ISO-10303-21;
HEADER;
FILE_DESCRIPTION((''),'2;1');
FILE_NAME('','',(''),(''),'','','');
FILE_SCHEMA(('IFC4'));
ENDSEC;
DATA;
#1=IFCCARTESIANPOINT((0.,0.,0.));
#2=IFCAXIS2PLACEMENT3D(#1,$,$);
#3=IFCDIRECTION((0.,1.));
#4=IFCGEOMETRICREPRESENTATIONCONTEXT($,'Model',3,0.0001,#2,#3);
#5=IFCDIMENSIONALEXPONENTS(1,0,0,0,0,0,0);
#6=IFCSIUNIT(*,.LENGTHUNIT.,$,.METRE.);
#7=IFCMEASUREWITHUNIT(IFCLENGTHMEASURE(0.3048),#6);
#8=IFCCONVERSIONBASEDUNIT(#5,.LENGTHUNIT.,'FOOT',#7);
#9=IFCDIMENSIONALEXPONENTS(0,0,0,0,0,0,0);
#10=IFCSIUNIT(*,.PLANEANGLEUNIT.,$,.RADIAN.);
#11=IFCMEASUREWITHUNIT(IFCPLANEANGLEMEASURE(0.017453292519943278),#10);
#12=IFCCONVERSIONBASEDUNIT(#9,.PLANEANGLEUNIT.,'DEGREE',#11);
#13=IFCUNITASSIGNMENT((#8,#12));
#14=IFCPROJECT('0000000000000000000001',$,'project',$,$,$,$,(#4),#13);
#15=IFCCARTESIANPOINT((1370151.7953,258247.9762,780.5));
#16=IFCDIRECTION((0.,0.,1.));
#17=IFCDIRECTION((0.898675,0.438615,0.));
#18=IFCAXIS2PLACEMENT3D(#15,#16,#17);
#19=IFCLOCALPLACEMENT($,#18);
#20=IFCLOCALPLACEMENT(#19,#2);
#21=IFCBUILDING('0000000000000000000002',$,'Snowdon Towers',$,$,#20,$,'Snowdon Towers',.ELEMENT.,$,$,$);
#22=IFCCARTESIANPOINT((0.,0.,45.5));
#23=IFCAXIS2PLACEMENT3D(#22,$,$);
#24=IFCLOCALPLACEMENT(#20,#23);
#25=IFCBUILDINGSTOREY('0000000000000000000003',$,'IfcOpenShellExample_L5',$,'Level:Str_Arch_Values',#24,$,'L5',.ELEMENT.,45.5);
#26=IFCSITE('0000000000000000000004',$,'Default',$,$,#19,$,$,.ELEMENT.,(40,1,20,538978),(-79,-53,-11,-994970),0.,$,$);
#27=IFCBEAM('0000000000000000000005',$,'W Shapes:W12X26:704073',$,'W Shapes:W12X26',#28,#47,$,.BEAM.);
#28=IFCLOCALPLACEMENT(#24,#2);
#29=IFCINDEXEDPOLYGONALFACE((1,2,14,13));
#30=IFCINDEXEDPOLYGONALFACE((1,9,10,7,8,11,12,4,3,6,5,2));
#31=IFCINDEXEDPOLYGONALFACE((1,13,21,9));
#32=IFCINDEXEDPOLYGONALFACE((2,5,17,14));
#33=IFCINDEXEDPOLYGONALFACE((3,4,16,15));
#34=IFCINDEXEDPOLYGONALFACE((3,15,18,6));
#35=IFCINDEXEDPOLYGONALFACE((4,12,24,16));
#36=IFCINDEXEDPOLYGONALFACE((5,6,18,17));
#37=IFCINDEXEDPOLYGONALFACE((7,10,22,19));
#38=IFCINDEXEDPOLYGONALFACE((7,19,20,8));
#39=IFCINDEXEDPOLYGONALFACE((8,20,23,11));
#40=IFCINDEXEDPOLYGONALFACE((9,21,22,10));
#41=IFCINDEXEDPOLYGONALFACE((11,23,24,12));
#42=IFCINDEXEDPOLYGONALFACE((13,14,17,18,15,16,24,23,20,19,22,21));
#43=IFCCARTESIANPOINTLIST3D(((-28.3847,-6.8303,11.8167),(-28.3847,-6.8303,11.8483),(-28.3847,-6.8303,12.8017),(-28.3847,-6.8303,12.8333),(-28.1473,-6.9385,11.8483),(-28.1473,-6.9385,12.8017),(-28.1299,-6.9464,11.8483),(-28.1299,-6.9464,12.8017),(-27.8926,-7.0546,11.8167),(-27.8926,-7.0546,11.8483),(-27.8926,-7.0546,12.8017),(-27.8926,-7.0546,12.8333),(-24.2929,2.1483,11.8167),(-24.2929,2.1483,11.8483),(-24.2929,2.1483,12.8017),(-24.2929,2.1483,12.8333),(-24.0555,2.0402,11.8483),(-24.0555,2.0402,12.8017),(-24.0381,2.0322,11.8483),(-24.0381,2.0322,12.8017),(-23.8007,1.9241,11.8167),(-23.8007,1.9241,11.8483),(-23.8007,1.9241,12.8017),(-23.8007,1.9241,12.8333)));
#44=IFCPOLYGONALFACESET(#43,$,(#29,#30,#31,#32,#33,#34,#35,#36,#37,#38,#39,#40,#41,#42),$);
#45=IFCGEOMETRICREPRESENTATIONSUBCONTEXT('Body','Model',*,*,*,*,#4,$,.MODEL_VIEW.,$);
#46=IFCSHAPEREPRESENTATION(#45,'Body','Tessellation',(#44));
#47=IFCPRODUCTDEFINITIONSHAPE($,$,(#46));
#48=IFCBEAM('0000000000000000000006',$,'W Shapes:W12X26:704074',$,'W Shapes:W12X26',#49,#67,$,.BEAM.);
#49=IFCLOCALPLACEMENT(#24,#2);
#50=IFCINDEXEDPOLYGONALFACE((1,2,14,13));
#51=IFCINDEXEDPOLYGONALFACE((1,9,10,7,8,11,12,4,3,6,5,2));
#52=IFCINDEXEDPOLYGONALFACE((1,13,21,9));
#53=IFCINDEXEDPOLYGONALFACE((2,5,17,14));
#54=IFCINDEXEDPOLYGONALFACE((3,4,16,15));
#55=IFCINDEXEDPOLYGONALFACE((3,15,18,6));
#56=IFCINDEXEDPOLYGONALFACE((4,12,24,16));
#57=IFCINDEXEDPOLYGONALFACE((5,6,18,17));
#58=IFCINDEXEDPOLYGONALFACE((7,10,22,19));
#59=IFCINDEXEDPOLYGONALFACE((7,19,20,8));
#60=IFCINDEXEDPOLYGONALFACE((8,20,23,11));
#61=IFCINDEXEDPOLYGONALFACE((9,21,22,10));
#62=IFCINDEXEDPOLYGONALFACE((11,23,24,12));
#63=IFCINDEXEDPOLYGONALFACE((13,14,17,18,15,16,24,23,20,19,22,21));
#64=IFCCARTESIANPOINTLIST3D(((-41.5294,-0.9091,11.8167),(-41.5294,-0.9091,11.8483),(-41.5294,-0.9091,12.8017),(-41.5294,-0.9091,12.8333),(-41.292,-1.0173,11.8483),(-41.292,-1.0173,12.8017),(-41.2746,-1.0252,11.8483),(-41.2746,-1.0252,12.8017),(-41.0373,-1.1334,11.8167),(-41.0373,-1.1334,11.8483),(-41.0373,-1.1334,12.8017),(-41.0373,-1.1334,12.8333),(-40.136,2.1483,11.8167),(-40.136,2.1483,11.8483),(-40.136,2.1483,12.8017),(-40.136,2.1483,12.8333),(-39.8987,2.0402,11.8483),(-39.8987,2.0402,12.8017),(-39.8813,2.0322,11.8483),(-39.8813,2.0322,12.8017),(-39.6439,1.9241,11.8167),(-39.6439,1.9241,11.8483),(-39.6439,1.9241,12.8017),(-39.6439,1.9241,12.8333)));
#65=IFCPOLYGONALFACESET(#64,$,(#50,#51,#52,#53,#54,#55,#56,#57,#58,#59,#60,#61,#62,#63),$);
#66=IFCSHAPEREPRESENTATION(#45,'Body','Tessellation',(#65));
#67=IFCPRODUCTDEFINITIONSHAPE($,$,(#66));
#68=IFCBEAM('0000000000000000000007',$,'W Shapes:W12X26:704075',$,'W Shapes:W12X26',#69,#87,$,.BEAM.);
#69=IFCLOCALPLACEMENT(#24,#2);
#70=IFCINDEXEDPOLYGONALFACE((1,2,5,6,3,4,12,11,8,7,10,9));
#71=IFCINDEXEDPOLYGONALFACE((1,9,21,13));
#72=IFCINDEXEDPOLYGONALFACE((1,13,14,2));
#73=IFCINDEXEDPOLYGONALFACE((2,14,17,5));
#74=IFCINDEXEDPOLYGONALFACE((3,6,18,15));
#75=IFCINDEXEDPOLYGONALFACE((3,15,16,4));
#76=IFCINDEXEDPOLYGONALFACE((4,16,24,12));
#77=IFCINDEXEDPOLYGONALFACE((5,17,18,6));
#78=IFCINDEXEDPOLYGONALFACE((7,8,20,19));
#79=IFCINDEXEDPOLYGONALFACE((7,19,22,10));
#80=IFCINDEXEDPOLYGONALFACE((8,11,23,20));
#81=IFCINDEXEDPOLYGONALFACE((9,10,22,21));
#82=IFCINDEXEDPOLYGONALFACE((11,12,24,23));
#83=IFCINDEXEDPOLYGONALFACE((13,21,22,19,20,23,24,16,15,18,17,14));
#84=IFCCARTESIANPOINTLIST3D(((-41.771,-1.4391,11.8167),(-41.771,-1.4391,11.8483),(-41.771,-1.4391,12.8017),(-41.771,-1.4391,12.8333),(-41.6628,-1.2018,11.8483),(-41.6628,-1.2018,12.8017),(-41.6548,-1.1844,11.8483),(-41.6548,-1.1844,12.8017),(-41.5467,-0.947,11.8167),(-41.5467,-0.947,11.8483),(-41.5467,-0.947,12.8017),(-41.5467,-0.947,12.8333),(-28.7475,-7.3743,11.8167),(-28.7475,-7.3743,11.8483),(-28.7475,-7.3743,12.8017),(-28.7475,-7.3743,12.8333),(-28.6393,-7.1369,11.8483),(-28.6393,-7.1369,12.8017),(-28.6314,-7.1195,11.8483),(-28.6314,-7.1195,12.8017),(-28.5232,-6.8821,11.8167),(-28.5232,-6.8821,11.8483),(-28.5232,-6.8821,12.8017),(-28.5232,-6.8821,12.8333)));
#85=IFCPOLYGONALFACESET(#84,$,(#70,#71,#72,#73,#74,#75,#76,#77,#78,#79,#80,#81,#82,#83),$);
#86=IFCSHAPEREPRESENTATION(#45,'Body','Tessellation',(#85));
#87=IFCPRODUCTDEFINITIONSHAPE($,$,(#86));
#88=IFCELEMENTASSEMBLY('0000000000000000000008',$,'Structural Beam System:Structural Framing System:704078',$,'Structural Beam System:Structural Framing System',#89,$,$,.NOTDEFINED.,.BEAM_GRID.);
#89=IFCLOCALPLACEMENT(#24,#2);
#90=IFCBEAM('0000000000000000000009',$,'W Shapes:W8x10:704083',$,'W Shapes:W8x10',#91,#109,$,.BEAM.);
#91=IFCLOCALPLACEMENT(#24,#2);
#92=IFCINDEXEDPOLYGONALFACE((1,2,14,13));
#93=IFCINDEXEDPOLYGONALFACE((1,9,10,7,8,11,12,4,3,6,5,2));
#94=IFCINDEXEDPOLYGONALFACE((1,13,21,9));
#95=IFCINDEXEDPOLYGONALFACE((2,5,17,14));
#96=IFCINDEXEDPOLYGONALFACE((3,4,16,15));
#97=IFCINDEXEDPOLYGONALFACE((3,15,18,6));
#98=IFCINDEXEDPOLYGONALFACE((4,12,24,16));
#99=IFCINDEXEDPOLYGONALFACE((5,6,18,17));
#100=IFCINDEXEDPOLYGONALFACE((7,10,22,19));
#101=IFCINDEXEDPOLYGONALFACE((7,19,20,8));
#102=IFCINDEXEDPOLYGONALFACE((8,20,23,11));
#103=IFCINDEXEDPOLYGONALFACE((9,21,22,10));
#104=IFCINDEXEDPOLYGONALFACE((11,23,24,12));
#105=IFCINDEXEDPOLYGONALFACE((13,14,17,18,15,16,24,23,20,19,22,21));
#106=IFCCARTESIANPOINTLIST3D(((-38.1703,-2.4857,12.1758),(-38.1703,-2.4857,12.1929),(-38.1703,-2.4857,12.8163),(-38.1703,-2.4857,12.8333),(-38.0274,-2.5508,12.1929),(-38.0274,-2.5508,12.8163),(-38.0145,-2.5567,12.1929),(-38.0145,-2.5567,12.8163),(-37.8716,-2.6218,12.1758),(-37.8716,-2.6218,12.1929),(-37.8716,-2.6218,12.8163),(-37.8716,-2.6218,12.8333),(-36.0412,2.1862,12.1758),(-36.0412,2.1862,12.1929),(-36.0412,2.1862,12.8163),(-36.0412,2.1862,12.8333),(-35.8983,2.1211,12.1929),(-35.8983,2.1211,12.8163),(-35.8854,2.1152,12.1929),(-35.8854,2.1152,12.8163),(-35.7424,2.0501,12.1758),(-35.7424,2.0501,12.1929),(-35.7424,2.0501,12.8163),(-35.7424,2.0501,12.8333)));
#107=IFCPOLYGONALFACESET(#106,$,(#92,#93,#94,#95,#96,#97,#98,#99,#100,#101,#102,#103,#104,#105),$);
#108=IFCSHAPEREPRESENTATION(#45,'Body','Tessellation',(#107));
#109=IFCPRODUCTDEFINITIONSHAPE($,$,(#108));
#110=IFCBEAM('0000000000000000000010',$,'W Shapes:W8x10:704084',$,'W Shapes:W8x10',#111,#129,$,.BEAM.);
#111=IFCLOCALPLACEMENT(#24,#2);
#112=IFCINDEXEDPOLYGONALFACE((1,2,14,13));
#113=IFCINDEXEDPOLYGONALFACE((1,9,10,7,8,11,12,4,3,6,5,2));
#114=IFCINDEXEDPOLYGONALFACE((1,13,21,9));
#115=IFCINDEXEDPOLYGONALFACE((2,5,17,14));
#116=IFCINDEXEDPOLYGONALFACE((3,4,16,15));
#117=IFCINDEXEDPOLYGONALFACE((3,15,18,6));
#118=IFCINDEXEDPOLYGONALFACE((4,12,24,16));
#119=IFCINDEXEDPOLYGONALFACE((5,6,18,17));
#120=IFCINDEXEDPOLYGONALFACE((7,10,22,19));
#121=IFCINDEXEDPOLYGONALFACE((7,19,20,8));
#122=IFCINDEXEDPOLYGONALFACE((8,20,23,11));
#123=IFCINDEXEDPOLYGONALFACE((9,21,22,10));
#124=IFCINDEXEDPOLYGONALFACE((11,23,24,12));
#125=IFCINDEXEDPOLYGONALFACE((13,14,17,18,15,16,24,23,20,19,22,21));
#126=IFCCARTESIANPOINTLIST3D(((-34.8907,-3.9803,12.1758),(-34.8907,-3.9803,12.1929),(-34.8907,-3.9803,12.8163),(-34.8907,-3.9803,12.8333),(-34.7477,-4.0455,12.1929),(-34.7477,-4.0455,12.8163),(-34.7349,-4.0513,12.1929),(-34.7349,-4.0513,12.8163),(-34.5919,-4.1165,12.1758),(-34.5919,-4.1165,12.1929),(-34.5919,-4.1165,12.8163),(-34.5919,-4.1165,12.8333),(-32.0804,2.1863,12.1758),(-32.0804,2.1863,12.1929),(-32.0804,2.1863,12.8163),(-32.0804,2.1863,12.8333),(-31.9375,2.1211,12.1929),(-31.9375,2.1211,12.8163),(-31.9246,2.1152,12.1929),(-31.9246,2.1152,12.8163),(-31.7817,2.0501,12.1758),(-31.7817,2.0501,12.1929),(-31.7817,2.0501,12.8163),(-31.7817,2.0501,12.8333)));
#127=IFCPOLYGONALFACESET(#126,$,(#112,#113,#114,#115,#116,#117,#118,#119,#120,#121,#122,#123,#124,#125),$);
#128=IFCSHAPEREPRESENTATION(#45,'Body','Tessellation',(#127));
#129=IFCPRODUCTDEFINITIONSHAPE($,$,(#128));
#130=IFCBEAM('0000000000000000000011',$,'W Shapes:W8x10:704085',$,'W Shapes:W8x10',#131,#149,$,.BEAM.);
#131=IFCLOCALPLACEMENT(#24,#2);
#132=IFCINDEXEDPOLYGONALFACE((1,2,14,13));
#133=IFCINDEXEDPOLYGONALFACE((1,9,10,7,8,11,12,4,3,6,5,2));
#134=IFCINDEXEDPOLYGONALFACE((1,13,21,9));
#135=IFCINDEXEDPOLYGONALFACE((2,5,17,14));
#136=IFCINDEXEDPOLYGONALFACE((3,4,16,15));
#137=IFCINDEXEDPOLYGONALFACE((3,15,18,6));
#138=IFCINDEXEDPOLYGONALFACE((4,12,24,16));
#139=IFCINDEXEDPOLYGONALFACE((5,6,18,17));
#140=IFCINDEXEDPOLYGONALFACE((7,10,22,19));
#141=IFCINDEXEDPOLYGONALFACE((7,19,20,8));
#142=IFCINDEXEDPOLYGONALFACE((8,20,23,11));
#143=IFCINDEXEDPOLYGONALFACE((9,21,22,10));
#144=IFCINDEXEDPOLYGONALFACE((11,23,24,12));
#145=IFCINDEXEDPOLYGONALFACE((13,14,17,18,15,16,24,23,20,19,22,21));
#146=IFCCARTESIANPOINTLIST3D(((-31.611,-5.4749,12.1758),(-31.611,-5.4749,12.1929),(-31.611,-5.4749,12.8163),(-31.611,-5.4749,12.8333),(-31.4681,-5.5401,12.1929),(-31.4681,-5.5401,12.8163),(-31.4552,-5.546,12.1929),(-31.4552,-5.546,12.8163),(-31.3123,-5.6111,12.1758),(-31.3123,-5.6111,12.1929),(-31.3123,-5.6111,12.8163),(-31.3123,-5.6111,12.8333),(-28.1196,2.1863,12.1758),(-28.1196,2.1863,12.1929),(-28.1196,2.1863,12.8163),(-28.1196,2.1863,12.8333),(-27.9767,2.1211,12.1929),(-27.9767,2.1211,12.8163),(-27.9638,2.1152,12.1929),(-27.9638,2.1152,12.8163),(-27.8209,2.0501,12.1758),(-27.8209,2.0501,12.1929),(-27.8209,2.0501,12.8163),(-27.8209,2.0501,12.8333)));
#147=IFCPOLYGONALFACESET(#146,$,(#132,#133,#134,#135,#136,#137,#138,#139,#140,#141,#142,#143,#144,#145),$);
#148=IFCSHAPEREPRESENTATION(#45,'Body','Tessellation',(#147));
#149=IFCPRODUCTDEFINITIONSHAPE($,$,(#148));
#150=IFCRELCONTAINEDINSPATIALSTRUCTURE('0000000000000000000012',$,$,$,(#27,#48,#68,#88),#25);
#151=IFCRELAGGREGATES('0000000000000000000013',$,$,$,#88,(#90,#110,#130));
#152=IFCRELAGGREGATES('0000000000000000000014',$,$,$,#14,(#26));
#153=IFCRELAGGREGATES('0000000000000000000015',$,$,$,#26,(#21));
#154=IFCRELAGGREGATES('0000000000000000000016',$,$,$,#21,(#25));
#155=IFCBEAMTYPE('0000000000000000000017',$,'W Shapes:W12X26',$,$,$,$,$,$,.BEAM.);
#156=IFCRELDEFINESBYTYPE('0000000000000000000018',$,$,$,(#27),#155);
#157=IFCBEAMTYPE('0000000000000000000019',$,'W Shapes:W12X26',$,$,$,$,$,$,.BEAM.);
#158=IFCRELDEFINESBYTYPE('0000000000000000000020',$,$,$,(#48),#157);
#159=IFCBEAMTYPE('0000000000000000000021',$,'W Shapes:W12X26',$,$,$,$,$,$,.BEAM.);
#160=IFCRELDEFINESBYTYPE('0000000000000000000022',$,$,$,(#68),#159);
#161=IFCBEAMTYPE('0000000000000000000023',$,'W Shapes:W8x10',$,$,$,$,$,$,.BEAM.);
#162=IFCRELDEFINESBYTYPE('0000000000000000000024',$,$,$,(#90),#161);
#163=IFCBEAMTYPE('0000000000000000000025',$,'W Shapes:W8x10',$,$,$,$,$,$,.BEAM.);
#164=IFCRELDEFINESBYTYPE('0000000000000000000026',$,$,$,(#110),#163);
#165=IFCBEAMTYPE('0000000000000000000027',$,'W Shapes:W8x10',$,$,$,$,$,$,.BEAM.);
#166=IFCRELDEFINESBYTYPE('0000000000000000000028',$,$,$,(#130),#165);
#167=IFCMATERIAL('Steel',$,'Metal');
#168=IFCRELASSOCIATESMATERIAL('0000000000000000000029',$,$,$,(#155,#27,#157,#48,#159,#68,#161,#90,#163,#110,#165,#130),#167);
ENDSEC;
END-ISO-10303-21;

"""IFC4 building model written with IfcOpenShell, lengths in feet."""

from ifc_helpers import new_model, entity, si_unit, converted_unit, direction, frame, origin, place, context, subcontext, project, spatial, indexed_curve, outline, extrude, source, transform, mapped, material, type_object, type_shapes, element, aggregate, save


model = new_model("IFC4")

# Units and contexts
model_context = context("Model", 3, precision=0.0001, world=origin(), true_north=direction((0.0, 1.0)))
body_context = subcontext(model_context, "Body", "Model", "MODEL_VIEW")
ifc_project = project(units=[converted_unit("LENGTHUNIT", "FOOT", entity("IfcLengthMeasure", 0.3048), si_unit("LENGTHUNIT", "METRE"), dimensions=[1, 0, 0, 0, 0, 0, 0]), converted_unit("PLANEANGLEUNIT", "DEGREE", entity("IfcPlaneAngleMeasure", 0.017453292519943278), si_unit("PLANEANGLEUNIT", "RADIAN"), dimensions=[0, 0, 0, 0, 0, 0, 0])], contexts=[model_context])

# Site, building, storey
site_placement = place(None, frame((1370151.7953, 258247.9762, 780.5), z_axis=(0.0, 0.0, 1.0), x_axis=(0.898675, 0.438615, 0.0)))
site = spatial("IfcSite", under=ifc_project, at=site_placement, Name="Default", CompositionType="ELEMENT", RefLatitude=(40, 1, 20, 538978), RefLongitude=(-79, -53, -11, -994970), RefElevation=0.0)
building_placement = place(site_placement, origin())
building = spatial("IfcBuilding", under=site, at=building_placement, Name="Snowdon Towers", LongName="Snowdon Towers", CompositionType="ELEMENT")
storey_placement = place(building_placement, frame((0.0, 0.0, 45.5)))
storey = spatial("IfcBuildingStorey", under=building, at=storey_placement, Name="IfcOpenShellExample_L5", ObjectType="Level:Str_Arch_Values", LongName="L5", CompositionType="ELEMENT", Elevation=45.5)

# Shared definitions
ifc_material = material(Name="Steel", Category="Metal")

# Beams
beam_type_1 = type_object("IfcBeamType", Name="W Shapes:W12X26", PredefinedType="BEAM", material=ifc_material)
shared_shape_1 = source(origin(), body_context, "Body", "SweptSolid", [
    extrude(outline(indexed_curve([(-0.2704, -0.4767), (-0.2704, -0.5083), (0.2704, -0.5083), (0.2704, -0.4767), (0.0096, -0.4767), (0.0096, 0.4767), (0.2704, 0.4767), (0.2704, 0.5083), (-0.2704, 0.5083), (-0.2704, 0.4767), (-0.0096, 0.4767), (-0.0096, -0.4767), (-0.2704, -0.4767)], self_intersect=False)), frame((-5.0009, 0.0, 0.0), z_axis=(-1.0, 0.0, 0.0), x_axis=(0.0, -1.0, 0.0)), (0.0, 0.0, -1.0), 9.8671),
])
type_shapes(beam_type_1, [shared_shape_1])
beam_1_placement = place(storey_placement, frame((-26.0648, -2.3919, 12.325), z_axis=(0.0, 0.0, 1.0), x_axis=(0.414693, 0.909961, 0.0)))
element("IfcBeam", 1, at=beam_1_placement, inside=storey, type_object=beam_type_1, material=ifc_material, Name="W Shapes:W12X26:704073", ObjectType="W Shapes:W12X26", PredefinedType="BEAM", context=body_context, shape_type="MappedRepresentation", body=[
    mapped(shared_shape_1, transform((0.0, 0.0, 0.0), scale=1.0)),
])
beam_type_2 = type_object("IfcBeamType", Name="W Shapes:W12X26", PredefinedType="BEAM", material=ifc_material)
shared_shape_2 = source(origin(), body_context, "Body", "SweptSolid", [
    extrude(outline(indexed_curve([(-0.2704, -0.4767), (-0.2704, -0.5083), (0.2704, -0.5083), (0.2704, -0.4767), (0.0096, -0.4767), (0.0096, 0.4767), (0.2704, 0.4767), (0.2704, 0.5083), (-0.2704, 0.5083), (-0.2704, 0.4767), (-0.0096, 0.4767), (-0.0096, -0.4767), (-0.2704, -0.4767)], self_intersect=False)), frame((-1.7788, 0.0, 0.0), z_axis=(-1.0, 0.0, 0.0), x_axis=(0.0, -1.0, 0.0)), (0.0, 0.0, -1.0), 3.3599),
])
type_shapes(beam_type_2, [shared_shape_2])
beam_2_placement = place(storey_placement, frame((-40.5457, 0.5974, 12.325), z_axis=(0.0, 0.0, 1.0), x_axis=(0.414693, 0.909961, 0.0)))
element("IfcBeam", 2, at=beam_2_placement, inside=storey, type_object=beam_type_2, material=ifc_material, Name="W Shapes:W12X26:704074", ObjectType="W Shapes:W12X26", PredefinedType="BEAM", context=body_context, shape_type="MappedRepresentation", body=[
    mapped(shared_shape_2, transform((0.0, 0.0, 0.0), scale=1.0)),
])
beam_type_3 = type_object("IfcBeamType", Name="W Shapes:W12X26", PredefinedType="BEAM", material=ifc_material)
shared_shape_3 = source(origin(), body_context, "Body", "SweptSolid", [
    extrude(outline(indexed_curve([(-0.2704, -0.4767), (-0.2704, -0.5083), (0.2704, -0.5083), (0.2704, -0.4767), (0.0096, -0.4767), (0.0096, 0.4767), (0.2704, 0.4767), (0.2704, 0.5083), (-0.2704, 0.5083), (-0.2704, 0.4767), (-0.0096, 0.4767), (-0.0096, -0.4767), (-0.2704, -0.4767)], self_intersect=False)), frame((-7.4788, 0.0, 0.0), z_axis=(-1.0, 0.0, 0.0), x_axis=(0.0, -1.0, 0.0)), (0.0, 0.0, -1.0), 14.3121),
])
type_shapes(beam_type_3, [shared_shape_3])
beam_3_placement = place(storey_placement, frame((-34.8534, -4.2945, 12.325), z_axis=(0.0, 0.0, 1.0), x_axis=(0.909961, -0.414693, 0.0)))
element("IfcBeam", 3, at=beam_3_placement, inside=storey, type_object=beam_type_3, material=ifc_material, Name="W Shapes:W12X26:704075", ObjectType="W Shapes:W12X26", PredefinedType="BEAM", context=body_context, shape_type="MappedRepresentation", body=[
    mapped(shared_shape_3, transform((0.0, 0.0, 0.0), scale=1.0)),
])

# Element assembly, beams
assembly_1_placement = place(storey_placement, origin())
assembly_1 = element("IfcElementAssembly", 4, at=assembly_1_placement, inside=storey, Name="Structural Beam System:Structural Framing System:704078", ObjectType="Structural Beam System:Structural Framing System", AssemblyPlace="NOTDEFINED", PredefinedType="BEAM_GRID")
beam_type_4 = type_object("IfcBeamType", Name="W Shapes:W8x10", PredefinedType="BEAM", material=ifc_material)
shared_shape_4 = source(origin(), body_context, "Body", "SweptSolid", [
    extrude(outline(indexed_curve([(-0.1642, -0.3117), (-0.1642, -0.3288), (0.1642, -0.3288), (0.1642, -0.3117), (0.0071, -0.3117), (0.0071, 0.3117), (0.1642, 0.3117), (0.1642, 0.3287), (-0.1642, 0.3287), (-0.1642, 0.3117), (-0.0071, 0.3117), (-0.0071, -0.3117), (-0.1642, -0.3117)], self_intersect=False)), frame((-2.6417, 0.0, 0.0), z_axis=(-1.0, 0.0, 0.0), x_axis=(0.0, -1.0, 0.0)), (0.0, 0.0, -1.0), 5.1342),
])
type_shapes(beam_type_4, [shared_shape_4])
beam_4_placement = place(assembly_1_placement, frame((-36.9255, -0.1499, 12.5046), z_axis=(0.0, 0.0, 1.0), x_axis=(0.414693, 0.909961, 0.0)))
beam_4 = element("IfcBeam", 5, at=beam_4_placement, type_object=beam_type_4, material=ifc_material, Name="W Shapes:W8x10:704083", ObjectType="W Shapes:W8x10", PredefinedType="BEAM", context=body_context, shape_type="MappedRepresentation", body=[
    mapped(shared_shape_4, transform((0.0, 0.0, 0.0), scale=1.0)),
])
beam_type_5 = type_object("IfcBeamType", Name="W Shapes:W8x10", PredefinedType="BEAM", material=ifc_material)
shared_shape_5 = source(origin(), body_context, "Body", "SweptSolid", [
    extrude(outline(indexed_curve([(-0.1642, -0.3117), (-0.1642, -0.3288), (0.1642, -0.3288), (0.1642, -0.3117), (0.0071, -0.3117), (0.0071, 0.3117), (0.1642, 0.3117), (0.1642, 0.3287), (-0.1642, 0.3287), (-0.1642, 0.3117), (-0.0071, 0.3117), (-0.0071, -0.3117), (-0.1642, -0.3117)], self_intersect=False)), frame((-3.463, 0.0, 0.0), z_axis=(-1.0, 0.0, 0.0), x_axis=(0.0, -1.0, 0.0)), (0.0, 0.0, -1.0), 6.7767),
])
type_shapes(beam_type_5, [shared_shape_5])
beam_5_placement = place(assembly_1_placement, frame((-33.3052, -0.8972, 12.5046), z_axis=(0.0, 0.0, 1.0), x_axis=(0.414693, 0.909961, 0.0)))
beam_5 = element("IfcBeam", 6, at=beam_5_placement, type_object=beam_type_5, material=ifc_material, Name="W Shapes:W8x10:704084", ObjectType="W Shapes:W8x10", PredefinedType="BEAM", context=body_context, shape_type="MappedRepresentation", body=[
    mapped(shared_shape_5, transform((0.0, 0.0, 0.0), scale=1.0)),
])
beam_type_6 = type_object("IfcBeamType", Name="W Shapes:W8x10", PredefinedType="BEAM", material=ifc_material)
shared_shape_6 = source(origin(), body_context, "Body", "SweptSolid", [
    extrude(outline(indexed_curve([(-0.1642, -0.3117), (-0.1642, -0.3288), (0.1642, -0.3288), (0.1642, -0.3117), (0.0071, -0.3117), (0.0071, 0.3117), (0.1642, 0.3117), (0.1642, 0.3287), (-0.1642, 0.3287), (-0.1642, 0.3117), (-0.0071, 0.3117), (-0.0071, -0.3117), (-0.1642, -0.3117)], self_intersect=False)), frame((-4.2842, 0.0, 0.0), z_axis=(-1.0, 0.0, 0.0), x_axis=(0.0, -1.0, 0.0)), (0.0, 0.0, -1.0), 8.4192),
])
type_shapes(beam_type_6, [shared_shape_6])
beam_6_placement = place(assembly_1_placement, frame((-29.685, -1.6445, 12.5046), z_axis=(0.0, 0.0, 1.0), x_axis=(0.414693, 0.909961, 0.0)))
beam_6 = element("IfcBeam", 7, at=beam_6_placement, type_object=beam_type_6, material=ifc_material, Name="W Shapes:W8x10:704085", ObjectType="W Shapes:W8x10", PredefinedType="BEAM", context=body_context, shape_type="MappedRepresentation", body=[
    mapped(shared_shape_6, transform((0.0, 0.0, 0.0), scale=1.0)),
])
aggregate(assembly_1, [beam_4, beam_5, beam_6])

save(model, "model.ifc")
